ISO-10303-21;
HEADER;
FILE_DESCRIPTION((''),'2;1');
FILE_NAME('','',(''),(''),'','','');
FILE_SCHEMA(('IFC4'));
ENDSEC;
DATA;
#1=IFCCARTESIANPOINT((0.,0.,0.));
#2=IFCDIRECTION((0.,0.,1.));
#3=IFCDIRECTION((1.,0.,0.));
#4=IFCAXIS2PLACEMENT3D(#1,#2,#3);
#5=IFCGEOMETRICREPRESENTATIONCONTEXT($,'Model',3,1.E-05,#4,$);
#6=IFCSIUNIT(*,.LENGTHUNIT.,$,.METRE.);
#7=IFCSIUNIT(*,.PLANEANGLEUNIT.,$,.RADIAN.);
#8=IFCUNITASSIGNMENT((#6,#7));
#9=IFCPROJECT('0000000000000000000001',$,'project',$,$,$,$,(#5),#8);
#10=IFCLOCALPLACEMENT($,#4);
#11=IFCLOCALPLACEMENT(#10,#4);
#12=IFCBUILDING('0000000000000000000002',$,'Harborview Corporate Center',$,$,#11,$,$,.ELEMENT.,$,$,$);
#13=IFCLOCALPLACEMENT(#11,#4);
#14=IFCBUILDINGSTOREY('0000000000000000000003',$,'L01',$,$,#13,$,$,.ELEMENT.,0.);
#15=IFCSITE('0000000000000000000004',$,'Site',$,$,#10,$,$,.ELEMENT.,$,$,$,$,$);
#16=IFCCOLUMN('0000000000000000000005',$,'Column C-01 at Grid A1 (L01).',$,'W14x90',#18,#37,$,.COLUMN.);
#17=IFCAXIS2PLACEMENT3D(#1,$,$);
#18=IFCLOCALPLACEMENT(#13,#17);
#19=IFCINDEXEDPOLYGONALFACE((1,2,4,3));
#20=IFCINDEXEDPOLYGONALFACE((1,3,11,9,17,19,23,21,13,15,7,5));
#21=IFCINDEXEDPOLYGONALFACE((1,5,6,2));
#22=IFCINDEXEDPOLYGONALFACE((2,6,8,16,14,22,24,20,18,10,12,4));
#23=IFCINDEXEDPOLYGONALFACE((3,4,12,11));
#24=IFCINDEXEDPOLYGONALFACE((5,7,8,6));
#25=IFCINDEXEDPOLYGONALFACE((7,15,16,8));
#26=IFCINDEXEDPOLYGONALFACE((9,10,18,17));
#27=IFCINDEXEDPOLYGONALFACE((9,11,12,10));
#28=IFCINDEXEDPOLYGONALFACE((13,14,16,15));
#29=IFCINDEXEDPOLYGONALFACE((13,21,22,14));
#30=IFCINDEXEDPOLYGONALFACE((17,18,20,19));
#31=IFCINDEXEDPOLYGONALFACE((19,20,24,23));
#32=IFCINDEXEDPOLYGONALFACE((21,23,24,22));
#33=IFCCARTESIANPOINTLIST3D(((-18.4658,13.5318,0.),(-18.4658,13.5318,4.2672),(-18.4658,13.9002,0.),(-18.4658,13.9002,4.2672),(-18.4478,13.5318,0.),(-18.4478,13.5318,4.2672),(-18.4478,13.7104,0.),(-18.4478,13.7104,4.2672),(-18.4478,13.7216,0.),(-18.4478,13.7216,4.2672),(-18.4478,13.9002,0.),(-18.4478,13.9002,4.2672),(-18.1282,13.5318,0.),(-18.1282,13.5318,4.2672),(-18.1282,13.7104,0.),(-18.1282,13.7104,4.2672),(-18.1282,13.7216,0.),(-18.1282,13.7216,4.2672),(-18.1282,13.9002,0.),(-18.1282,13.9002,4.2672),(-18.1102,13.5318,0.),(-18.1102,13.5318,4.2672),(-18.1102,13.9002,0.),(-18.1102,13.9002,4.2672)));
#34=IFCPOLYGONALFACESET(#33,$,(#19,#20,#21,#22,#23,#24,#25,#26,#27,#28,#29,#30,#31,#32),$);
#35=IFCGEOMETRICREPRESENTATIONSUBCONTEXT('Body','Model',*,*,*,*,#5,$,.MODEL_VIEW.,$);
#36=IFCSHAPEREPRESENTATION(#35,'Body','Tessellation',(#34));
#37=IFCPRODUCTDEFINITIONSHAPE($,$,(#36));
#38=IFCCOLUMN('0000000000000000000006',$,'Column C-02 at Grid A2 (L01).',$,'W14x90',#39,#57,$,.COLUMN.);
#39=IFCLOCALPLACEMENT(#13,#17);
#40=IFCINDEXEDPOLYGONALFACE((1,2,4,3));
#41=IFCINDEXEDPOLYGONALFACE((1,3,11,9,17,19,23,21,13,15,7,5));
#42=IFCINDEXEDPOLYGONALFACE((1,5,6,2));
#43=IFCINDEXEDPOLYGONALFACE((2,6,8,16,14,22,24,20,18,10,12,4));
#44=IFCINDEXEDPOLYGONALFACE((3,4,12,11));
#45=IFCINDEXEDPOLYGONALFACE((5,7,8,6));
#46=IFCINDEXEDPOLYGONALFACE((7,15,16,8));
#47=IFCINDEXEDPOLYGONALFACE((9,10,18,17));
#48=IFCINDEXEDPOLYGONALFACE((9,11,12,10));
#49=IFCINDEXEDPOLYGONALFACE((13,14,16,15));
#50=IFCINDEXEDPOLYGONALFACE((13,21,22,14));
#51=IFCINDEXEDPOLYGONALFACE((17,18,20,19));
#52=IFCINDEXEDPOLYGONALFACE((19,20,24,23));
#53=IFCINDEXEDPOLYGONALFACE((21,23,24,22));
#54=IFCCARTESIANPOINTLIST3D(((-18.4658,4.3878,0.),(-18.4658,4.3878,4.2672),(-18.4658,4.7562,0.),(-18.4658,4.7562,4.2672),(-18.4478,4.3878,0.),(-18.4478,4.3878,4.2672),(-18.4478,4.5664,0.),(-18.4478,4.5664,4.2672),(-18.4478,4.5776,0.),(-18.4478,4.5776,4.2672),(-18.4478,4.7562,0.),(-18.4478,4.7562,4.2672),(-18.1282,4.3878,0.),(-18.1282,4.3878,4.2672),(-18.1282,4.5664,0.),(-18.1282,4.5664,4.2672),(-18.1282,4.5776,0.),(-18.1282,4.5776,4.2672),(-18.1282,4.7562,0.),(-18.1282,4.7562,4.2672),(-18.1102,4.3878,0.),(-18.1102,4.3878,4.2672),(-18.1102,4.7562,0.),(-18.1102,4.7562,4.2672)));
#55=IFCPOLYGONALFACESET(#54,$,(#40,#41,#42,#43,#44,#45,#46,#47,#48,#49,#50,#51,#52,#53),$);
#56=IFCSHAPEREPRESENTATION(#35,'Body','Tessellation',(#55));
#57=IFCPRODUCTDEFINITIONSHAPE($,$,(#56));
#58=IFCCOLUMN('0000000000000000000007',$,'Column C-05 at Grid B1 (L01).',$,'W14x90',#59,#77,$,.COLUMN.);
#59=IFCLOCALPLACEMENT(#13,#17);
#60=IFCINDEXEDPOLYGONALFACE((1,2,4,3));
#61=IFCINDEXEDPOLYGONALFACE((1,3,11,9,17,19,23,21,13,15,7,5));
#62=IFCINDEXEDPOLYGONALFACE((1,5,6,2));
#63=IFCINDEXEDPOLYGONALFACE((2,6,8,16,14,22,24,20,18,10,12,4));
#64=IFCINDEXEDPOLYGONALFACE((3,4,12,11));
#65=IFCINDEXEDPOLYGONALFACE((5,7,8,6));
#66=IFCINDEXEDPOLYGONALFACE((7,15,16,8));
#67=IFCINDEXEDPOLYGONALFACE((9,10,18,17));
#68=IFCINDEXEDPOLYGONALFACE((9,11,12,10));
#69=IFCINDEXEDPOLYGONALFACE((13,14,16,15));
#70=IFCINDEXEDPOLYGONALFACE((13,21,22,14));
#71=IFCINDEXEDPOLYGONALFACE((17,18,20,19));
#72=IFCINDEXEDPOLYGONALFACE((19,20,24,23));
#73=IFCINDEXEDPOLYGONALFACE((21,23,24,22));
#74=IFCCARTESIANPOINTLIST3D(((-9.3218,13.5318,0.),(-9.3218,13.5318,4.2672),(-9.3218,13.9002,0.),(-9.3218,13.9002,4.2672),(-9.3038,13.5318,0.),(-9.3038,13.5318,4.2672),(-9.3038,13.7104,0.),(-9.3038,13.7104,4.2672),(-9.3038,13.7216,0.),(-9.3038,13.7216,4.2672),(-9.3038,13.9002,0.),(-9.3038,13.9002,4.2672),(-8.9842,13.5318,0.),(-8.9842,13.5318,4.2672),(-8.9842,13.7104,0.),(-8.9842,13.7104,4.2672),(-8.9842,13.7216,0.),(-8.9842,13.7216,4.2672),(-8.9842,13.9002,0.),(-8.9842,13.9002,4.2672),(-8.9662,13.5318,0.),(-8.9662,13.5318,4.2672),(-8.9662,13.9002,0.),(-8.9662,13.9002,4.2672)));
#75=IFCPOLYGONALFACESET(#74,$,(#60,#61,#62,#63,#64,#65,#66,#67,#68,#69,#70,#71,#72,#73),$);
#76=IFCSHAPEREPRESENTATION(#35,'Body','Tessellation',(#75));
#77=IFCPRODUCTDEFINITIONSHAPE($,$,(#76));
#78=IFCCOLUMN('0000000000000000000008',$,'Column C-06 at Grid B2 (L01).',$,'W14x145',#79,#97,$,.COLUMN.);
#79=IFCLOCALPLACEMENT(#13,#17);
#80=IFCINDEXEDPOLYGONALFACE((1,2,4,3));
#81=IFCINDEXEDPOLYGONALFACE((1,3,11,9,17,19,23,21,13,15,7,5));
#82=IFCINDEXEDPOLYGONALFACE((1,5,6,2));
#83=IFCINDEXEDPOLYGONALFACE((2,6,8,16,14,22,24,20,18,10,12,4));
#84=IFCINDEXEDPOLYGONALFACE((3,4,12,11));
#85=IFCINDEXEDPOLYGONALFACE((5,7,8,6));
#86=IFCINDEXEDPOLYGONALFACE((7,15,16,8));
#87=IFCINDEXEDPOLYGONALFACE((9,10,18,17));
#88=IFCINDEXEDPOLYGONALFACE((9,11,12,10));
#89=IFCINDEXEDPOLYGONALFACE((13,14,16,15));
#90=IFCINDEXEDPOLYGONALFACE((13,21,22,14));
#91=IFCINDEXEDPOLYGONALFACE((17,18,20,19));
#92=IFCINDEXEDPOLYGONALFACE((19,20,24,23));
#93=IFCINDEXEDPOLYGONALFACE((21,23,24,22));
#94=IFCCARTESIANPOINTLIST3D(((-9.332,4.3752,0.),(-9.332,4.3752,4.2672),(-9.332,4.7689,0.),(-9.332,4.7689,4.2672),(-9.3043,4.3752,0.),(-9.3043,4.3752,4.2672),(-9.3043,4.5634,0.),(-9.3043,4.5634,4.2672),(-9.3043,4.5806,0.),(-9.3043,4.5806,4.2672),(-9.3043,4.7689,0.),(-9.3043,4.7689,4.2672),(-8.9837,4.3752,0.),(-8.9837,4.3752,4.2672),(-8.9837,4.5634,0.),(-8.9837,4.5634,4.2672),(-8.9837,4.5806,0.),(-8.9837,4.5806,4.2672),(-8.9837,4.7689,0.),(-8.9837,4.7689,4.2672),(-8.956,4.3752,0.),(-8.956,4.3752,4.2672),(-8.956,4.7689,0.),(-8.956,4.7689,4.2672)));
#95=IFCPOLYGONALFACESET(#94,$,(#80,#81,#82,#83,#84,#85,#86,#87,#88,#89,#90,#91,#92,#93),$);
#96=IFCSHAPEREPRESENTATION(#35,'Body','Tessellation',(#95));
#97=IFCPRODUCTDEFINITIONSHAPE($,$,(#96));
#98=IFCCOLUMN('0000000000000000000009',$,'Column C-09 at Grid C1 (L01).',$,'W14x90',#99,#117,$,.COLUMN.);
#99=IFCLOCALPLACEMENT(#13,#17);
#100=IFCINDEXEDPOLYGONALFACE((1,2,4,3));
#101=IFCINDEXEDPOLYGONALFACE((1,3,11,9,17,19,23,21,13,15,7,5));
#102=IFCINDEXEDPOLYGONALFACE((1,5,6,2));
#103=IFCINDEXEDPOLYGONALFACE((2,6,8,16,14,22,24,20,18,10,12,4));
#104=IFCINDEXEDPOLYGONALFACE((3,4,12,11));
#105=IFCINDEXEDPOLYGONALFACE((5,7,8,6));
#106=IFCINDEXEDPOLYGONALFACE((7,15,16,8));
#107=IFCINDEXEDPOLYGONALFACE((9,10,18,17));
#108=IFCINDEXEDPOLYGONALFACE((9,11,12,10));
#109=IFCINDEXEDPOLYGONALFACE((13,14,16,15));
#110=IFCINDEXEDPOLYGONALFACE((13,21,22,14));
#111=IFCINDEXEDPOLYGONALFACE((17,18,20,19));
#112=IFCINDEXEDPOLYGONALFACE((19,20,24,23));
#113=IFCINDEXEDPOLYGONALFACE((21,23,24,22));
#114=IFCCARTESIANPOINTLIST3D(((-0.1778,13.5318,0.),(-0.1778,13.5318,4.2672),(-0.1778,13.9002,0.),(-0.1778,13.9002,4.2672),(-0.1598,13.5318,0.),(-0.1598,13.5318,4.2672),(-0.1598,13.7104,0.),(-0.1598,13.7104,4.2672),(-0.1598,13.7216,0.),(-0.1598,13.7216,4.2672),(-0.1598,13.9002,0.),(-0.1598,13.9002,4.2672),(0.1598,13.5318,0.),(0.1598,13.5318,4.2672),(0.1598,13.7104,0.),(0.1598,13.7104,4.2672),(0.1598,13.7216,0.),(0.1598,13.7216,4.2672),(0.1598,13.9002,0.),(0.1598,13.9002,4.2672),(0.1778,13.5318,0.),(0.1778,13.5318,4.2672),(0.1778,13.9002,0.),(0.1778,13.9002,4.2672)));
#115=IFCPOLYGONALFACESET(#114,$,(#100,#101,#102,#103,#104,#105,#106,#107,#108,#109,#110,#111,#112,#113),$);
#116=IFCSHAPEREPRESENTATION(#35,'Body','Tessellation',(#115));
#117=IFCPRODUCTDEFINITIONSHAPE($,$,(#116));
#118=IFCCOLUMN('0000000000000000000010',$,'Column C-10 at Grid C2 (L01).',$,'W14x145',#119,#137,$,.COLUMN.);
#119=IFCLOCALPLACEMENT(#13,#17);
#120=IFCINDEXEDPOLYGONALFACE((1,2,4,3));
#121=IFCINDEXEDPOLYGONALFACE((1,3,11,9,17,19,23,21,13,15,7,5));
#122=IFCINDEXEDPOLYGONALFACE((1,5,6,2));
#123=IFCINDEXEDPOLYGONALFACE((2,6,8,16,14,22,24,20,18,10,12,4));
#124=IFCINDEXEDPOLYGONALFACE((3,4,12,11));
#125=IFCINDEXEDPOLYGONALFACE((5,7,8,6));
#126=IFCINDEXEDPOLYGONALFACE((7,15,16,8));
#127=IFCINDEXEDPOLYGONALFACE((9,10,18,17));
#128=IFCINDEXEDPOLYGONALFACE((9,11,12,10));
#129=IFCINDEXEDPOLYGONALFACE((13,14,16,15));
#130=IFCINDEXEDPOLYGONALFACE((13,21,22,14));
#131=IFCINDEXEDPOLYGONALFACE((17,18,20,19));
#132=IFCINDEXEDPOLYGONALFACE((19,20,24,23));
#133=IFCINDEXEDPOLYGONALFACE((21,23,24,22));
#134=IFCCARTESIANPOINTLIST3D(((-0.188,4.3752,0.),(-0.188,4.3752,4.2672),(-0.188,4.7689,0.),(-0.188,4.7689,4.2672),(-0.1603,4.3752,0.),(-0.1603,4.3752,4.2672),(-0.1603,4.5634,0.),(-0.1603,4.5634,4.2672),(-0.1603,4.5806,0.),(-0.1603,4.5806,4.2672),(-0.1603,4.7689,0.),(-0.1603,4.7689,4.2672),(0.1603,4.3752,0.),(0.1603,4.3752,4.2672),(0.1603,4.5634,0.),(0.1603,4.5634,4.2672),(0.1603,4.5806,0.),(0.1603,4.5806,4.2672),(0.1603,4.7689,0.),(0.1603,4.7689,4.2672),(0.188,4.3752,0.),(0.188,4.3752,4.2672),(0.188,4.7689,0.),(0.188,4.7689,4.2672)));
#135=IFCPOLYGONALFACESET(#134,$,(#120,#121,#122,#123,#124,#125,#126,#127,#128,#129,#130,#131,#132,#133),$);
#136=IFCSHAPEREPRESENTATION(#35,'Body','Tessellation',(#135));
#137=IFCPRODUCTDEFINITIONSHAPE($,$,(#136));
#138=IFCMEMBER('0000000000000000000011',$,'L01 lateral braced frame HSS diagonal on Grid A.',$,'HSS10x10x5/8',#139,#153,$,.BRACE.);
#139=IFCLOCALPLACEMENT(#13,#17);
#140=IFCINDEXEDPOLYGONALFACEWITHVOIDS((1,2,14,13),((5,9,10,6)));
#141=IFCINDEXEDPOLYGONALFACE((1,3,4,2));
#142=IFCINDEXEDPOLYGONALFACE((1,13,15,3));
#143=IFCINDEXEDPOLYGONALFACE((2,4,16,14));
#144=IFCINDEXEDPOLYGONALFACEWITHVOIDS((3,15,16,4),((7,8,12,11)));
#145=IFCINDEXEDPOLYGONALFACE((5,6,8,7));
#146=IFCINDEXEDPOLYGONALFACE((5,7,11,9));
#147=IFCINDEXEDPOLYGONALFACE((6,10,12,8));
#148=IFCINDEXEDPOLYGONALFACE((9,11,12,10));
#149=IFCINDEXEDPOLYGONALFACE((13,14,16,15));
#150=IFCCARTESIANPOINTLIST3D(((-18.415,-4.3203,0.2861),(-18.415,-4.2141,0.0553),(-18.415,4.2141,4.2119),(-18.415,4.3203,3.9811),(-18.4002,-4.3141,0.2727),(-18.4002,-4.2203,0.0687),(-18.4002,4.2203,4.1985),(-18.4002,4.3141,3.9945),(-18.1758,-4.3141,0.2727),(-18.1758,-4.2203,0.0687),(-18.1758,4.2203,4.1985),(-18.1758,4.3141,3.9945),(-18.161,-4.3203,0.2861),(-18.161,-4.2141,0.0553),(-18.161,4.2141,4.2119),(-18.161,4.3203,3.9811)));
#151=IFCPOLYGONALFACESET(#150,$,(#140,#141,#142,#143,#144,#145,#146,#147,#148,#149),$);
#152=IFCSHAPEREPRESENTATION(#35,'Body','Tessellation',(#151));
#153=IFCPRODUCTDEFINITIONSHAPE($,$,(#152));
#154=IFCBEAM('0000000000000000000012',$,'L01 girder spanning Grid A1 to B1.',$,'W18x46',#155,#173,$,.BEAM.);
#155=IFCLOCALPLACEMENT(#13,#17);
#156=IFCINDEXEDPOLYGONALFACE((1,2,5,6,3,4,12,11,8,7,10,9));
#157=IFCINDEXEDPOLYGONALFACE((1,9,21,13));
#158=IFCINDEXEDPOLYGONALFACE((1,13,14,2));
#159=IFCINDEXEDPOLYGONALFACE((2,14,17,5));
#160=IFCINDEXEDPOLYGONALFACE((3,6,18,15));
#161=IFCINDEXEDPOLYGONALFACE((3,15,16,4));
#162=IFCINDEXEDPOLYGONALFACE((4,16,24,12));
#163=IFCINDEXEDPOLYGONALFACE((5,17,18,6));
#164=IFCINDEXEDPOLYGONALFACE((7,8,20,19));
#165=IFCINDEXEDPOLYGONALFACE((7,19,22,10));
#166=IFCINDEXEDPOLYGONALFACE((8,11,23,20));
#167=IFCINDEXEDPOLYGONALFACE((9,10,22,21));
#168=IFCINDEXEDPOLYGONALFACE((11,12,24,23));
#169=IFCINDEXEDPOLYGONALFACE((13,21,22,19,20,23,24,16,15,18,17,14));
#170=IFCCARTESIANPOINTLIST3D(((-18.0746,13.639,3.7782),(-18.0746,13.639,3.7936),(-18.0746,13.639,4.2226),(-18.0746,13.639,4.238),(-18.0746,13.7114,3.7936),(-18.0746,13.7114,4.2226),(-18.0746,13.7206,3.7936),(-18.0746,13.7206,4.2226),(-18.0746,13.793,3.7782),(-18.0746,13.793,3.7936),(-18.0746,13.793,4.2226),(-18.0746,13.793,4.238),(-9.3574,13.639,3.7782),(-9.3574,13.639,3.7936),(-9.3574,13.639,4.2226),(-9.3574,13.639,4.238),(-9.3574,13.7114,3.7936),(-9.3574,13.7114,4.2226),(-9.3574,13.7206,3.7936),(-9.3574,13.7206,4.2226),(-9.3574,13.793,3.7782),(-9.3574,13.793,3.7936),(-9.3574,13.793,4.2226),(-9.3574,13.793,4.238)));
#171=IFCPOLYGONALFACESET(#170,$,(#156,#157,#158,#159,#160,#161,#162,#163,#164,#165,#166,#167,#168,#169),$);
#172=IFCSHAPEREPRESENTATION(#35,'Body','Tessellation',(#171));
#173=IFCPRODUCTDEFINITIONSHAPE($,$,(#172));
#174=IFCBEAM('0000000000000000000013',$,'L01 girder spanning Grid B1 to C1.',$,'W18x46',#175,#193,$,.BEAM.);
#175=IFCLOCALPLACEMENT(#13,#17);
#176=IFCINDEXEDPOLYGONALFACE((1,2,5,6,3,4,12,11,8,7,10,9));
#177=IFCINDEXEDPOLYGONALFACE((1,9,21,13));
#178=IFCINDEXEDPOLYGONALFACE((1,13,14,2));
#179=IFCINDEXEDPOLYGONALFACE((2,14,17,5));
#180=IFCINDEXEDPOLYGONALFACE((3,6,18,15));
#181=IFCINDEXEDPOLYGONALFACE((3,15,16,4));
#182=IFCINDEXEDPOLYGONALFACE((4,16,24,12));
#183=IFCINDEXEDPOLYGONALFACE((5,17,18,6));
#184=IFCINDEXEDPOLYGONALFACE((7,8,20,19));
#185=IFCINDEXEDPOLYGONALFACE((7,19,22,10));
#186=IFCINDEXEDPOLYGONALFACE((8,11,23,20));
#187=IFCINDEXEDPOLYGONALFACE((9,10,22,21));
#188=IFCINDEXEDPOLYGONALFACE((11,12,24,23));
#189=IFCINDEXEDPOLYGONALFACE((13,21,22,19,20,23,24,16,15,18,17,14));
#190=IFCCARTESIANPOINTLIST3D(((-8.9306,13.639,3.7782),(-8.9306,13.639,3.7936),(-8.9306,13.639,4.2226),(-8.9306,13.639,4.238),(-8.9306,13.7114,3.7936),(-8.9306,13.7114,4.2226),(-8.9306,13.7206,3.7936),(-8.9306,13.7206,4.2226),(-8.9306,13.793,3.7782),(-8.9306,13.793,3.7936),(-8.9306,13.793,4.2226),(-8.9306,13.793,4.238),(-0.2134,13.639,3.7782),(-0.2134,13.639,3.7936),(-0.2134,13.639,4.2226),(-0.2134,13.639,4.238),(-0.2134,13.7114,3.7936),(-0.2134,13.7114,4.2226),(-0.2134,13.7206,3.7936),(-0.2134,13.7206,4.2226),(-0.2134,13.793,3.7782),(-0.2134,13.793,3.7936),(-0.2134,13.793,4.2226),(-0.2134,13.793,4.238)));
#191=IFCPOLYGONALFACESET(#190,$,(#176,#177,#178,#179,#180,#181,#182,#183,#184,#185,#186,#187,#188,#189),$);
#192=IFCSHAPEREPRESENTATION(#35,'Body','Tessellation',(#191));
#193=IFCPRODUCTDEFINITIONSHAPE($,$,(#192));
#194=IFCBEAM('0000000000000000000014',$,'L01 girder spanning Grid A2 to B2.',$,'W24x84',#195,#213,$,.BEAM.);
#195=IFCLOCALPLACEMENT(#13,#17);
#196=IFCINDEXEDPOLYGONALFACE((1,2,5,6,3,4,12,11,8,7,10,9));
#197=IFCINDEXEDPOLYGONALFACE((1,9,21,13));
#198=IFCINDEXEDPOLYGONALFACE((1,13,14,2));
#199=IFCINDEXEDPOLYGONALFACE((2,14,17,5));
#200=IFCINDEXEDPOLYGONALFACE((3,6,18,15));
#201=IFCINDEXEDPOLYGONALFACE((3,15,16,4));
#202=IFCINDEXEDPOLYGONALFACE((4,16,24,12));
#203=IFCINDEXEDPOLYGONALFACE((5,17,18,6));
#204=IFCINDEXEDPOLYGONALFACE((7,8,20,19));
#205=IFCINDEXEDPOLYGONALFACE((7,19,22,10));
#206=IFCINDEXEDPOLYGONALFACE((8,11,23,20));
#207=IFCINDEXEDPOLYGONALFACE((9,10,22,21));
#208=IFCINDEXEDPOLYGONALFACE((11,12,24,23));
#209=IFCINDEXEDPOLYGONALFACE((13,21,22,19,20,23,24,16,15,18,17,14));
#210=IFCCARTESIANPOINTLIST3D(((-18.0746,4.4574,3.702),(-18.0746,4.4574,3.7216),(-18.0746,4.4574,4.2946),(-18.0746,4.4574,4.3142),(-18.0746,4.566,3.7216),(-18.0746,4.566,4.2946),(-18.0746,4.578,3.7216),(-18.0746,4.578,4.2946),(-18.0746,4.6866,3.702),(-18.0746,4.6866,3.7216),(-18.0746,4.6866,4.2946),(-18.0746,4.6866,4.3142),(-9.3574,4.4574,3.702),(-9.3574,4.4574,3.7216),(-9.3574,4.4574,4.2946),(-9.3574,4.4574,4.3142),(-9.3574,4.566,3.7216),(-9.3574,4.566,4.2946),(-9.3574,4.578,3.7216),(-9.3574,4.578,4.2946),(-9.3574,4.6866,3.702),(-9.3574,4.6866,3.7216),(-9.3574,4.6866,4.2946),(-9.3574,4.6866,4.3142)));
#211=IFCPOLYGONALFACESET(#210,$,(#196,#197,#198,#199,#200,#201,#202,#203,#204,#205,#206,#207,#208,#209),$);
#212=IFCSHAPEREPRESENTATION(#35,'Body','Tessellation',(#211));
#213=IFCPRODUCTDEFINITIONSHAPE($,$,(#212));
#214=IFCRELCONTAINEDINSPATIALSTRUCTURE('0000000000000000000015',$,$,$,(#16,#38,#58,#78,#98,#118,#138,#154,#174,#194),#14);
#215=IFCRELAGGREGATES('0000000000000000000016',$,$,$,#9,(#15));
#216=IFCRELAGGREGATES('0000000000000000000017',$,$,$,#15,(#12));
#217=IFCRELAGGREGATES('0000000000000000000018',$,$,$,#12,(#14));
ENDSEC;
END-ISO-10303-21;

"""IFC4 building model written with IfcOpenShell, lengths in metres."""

from ifc_helpers import new_model, si_unit, frame, origin_with_axes, place, context, subcontext, project, spatial, hollow_rectangle, i_section, extrude, element, save


model = new_model("IFC4")

# Units and contexts
model_context = context("Model", 3, precision=1e-05, world=origin_with_axes())
body_context = subcontext(model_context, "Body", "Model", "MODEL_VIEW")
ifc_project = project(units=[si_unit("LENGTHUNIT", "METRE"), si_unit("PLANEANGLEUNIT", "RADIAN")], contexts=[model_context])

# Site, building, storey
site_placement = place(None, origin_with_axes())
site = spatial("IfcSite", under=ifc_project, at=site_placement, Name="Site", CompositionType="ELEMENT")
building_placement = place(site_placement, origin_with_axes())
building = spatial("IfcBuilding", under=site, at=building_placement, Name="Harborview Corporate Center", CompositionType="ELEMENT")
storey_placement = place(building_placement, origin_with_axes())
storey = spatial("IfcBuildingStorey", under=building, at=storey_placement, Name="L01", CompositionType="ELEMENT", Elevation=0.0)

# Columns
for number, where, z_axis, x_axis, name in (
    (1, (-18.288, 13.716, 0.0), (0.0, 0.0, 1.0), (0.0, 1.0, 0.0), "Column C-01 at Grid A1 (L01)."),
    (2, (-18.288, 4.572, 0.0), (0.0, 0.0, 1.0), (0.0, 1.0, 0.0), "Column C-02 at Grid A2 (L01)."),
    (3, (-9.144, 13.716, 0.0), (0.0, 0.0, 1.0), (0.0, 1.0, 0.0), "Column C-05 at Grid B1 (L01)."),
):
    element("IfcColumn", number, at=place(storey_placement, frame(where, z_axis=z_axis, x_axis=x_axis)), inside=storey, Name=name, ObjectType="W14x90", PredefinedType="COLUMN", context=body_context, shape_type="SweptSolid", body=[
        extrude(i_section(OverallWidth=0.3683, OverallDepth=0.3556, WebThickness=0.0112, FlangeThickness=0.018), origin_with_axes(), (0.0, 0.0, 1.0), 4.2672),
    ])
column_1_placement = place(storey_placement, frame((-9.144, 4.572, 0.0), z_axis=(0.0, 0.0, 1.0), x_axis=(0.0, 1.0, 0.0)))
element("IfcColumn", 4, at=column_1_placement, inside=storey, Name="Column C-06 at Grid B2 (L01).", ObjectType="W14x145", PredefinedType="COLUMN", context=body_context, shape_type="SweptSolid", body=[
    extrude(i_section(OverallWidth=0.3937, OverallDepth=0.3759, WebThickness=0.0173, FlangeThickness=0.0277), origin_with_axes(), (0.0, 0.0, 1.0), 4.2672),
])
column_2_placement = place(storey_placement, frame((0.0, 13.716, 0.0), z_axis=(0.0, 0.0, 1.0), x_axis=(0.0, 1.0, 0.0)))
element("IfcColumn", 5, at=column_2_placement, inside=storey, Name="Column C-09 at Grid C1 (L01).", ObjectType="W14x90", PredefinedType="COLUMN", context=body_context, shape_type="SweptSolid", body=[
    extrude(i_section(OverallWidth=0.3683, OverallDepth=0.3556, WebThickness=0.0112, FlangeThickness=0.018), origin_with_axes(), (0.0, 0.0, 1.0), 4.2672),
])
column_3_placement = place(storey_placement, frame((0.0, 4.572, 0.0), z_axis=(0.0, 0.0, 1.0), x_axis=(0.0, 1.0, 0.0)))
element("IfcColumn", 6, at=column_3_placement, inside=storey, Name="Column C-10 at Grid C2 (L01).", ObjectType="W14x145", PredefinedType="COLUMN", context=body_context, shape_type="SweptSolid", body=[
    extrude(i_section(OverallWidth=0.3937, OverallDepth=0.3759, WebThickness=0.0173, FlangeThickness=0.0277), origin_with_axes(), (0.0, 0.0, 1.0), 4.2672),
])

# Member
member_placement = place(storey_placement, frame((-18.288, -4.2672, 0.1707), z_axis=(0.0, 0.90849, 0.417906), x_axis=(-1.0, 0.0, 0.0)))
element("IfcMember", 7, at=member_placement, inside=storey, Name="L01 lateral braced frame HSS diagonal on Grid A.", ObjectType="HSS10x10x5/8", PredefinedType="BRACE", context=body_context, shape_type="SweptSolid", body=[
    extrude(hollow_rectangle(XDim=0.254, YDim=0.254, WallThickness=0.0148), origin_with_axes(), (0.0, 0.0, 1.0), 9.394),
])

# Beams
beam_1_placement = place(storey_placement, frame((-18.0746, 13.716, 4.0081), z_axis=(1.0, 0.0, 0.0), x_axis=(0.0, 1.0, 0.0)))
element("IfcBeam", 8, at=beam_1_placement, inside=storey, Name="L01 girder spanning Grid A1 to B1.", ObjectType="W18x46", PredefinedType="BEAM", context=body_context, shape_type="SweptSolid", body=[
    extrude(i_section(OverallWidth=0.1539, OverallDepth=0.4597, WebThickness=0.0091, FlangeThickness=0.0154), origin_with_axes(), (0.0, 0.0, 1.0), 8.7173),
])
beam_2_placement = place(storey_placement, frame((-8.9306, 13.716, 4.0081), z_axis=(1.0, 0.0, 0.0), x_axis=(0.0, 1.0, 0.0)))
element("IfcBeam", 9, at=beam_2_placement, inside=storey, Name="L01 girder spanning Grid B1 to C1.", ObjectType="W18x46", PredefinedType="BEAM", context=body_context, shape_type="SweptSolid", body=[
    extrude(i_section(OverallWidth=0.1539, OverallDepth=0.4597, WebThickness=0.0091, FlangeThickness=0.0154), origin_with_axes(), (0.0, 0.0, 1.0), 8.7173),
])
beam_3_placement = place(storey_placement, frame((-18.0746, 4.572, 4.0081), z_axis=(1.0, 0.0, 0.0), x_axis=(0.0, 1.0, 0.0)))
element("IfcBeam", 10, at=beam_3_placement, inside=storey, Name="L01 girder spanning Grid A2 to B2.", ObjectType="W24x84", PredefinedType="BEAM", context=body_context, shape_type="SweptSolid", body=[
    extrude(i_section(OverallWidth=0.2291, OverallDepth=0.6121, WebThickness=0.0119, FlangeThickness=0.0196), origin_with_axes(), (0.0, 0.0, 1.0), 8.7173),
])

save(model, "model.ifc")
